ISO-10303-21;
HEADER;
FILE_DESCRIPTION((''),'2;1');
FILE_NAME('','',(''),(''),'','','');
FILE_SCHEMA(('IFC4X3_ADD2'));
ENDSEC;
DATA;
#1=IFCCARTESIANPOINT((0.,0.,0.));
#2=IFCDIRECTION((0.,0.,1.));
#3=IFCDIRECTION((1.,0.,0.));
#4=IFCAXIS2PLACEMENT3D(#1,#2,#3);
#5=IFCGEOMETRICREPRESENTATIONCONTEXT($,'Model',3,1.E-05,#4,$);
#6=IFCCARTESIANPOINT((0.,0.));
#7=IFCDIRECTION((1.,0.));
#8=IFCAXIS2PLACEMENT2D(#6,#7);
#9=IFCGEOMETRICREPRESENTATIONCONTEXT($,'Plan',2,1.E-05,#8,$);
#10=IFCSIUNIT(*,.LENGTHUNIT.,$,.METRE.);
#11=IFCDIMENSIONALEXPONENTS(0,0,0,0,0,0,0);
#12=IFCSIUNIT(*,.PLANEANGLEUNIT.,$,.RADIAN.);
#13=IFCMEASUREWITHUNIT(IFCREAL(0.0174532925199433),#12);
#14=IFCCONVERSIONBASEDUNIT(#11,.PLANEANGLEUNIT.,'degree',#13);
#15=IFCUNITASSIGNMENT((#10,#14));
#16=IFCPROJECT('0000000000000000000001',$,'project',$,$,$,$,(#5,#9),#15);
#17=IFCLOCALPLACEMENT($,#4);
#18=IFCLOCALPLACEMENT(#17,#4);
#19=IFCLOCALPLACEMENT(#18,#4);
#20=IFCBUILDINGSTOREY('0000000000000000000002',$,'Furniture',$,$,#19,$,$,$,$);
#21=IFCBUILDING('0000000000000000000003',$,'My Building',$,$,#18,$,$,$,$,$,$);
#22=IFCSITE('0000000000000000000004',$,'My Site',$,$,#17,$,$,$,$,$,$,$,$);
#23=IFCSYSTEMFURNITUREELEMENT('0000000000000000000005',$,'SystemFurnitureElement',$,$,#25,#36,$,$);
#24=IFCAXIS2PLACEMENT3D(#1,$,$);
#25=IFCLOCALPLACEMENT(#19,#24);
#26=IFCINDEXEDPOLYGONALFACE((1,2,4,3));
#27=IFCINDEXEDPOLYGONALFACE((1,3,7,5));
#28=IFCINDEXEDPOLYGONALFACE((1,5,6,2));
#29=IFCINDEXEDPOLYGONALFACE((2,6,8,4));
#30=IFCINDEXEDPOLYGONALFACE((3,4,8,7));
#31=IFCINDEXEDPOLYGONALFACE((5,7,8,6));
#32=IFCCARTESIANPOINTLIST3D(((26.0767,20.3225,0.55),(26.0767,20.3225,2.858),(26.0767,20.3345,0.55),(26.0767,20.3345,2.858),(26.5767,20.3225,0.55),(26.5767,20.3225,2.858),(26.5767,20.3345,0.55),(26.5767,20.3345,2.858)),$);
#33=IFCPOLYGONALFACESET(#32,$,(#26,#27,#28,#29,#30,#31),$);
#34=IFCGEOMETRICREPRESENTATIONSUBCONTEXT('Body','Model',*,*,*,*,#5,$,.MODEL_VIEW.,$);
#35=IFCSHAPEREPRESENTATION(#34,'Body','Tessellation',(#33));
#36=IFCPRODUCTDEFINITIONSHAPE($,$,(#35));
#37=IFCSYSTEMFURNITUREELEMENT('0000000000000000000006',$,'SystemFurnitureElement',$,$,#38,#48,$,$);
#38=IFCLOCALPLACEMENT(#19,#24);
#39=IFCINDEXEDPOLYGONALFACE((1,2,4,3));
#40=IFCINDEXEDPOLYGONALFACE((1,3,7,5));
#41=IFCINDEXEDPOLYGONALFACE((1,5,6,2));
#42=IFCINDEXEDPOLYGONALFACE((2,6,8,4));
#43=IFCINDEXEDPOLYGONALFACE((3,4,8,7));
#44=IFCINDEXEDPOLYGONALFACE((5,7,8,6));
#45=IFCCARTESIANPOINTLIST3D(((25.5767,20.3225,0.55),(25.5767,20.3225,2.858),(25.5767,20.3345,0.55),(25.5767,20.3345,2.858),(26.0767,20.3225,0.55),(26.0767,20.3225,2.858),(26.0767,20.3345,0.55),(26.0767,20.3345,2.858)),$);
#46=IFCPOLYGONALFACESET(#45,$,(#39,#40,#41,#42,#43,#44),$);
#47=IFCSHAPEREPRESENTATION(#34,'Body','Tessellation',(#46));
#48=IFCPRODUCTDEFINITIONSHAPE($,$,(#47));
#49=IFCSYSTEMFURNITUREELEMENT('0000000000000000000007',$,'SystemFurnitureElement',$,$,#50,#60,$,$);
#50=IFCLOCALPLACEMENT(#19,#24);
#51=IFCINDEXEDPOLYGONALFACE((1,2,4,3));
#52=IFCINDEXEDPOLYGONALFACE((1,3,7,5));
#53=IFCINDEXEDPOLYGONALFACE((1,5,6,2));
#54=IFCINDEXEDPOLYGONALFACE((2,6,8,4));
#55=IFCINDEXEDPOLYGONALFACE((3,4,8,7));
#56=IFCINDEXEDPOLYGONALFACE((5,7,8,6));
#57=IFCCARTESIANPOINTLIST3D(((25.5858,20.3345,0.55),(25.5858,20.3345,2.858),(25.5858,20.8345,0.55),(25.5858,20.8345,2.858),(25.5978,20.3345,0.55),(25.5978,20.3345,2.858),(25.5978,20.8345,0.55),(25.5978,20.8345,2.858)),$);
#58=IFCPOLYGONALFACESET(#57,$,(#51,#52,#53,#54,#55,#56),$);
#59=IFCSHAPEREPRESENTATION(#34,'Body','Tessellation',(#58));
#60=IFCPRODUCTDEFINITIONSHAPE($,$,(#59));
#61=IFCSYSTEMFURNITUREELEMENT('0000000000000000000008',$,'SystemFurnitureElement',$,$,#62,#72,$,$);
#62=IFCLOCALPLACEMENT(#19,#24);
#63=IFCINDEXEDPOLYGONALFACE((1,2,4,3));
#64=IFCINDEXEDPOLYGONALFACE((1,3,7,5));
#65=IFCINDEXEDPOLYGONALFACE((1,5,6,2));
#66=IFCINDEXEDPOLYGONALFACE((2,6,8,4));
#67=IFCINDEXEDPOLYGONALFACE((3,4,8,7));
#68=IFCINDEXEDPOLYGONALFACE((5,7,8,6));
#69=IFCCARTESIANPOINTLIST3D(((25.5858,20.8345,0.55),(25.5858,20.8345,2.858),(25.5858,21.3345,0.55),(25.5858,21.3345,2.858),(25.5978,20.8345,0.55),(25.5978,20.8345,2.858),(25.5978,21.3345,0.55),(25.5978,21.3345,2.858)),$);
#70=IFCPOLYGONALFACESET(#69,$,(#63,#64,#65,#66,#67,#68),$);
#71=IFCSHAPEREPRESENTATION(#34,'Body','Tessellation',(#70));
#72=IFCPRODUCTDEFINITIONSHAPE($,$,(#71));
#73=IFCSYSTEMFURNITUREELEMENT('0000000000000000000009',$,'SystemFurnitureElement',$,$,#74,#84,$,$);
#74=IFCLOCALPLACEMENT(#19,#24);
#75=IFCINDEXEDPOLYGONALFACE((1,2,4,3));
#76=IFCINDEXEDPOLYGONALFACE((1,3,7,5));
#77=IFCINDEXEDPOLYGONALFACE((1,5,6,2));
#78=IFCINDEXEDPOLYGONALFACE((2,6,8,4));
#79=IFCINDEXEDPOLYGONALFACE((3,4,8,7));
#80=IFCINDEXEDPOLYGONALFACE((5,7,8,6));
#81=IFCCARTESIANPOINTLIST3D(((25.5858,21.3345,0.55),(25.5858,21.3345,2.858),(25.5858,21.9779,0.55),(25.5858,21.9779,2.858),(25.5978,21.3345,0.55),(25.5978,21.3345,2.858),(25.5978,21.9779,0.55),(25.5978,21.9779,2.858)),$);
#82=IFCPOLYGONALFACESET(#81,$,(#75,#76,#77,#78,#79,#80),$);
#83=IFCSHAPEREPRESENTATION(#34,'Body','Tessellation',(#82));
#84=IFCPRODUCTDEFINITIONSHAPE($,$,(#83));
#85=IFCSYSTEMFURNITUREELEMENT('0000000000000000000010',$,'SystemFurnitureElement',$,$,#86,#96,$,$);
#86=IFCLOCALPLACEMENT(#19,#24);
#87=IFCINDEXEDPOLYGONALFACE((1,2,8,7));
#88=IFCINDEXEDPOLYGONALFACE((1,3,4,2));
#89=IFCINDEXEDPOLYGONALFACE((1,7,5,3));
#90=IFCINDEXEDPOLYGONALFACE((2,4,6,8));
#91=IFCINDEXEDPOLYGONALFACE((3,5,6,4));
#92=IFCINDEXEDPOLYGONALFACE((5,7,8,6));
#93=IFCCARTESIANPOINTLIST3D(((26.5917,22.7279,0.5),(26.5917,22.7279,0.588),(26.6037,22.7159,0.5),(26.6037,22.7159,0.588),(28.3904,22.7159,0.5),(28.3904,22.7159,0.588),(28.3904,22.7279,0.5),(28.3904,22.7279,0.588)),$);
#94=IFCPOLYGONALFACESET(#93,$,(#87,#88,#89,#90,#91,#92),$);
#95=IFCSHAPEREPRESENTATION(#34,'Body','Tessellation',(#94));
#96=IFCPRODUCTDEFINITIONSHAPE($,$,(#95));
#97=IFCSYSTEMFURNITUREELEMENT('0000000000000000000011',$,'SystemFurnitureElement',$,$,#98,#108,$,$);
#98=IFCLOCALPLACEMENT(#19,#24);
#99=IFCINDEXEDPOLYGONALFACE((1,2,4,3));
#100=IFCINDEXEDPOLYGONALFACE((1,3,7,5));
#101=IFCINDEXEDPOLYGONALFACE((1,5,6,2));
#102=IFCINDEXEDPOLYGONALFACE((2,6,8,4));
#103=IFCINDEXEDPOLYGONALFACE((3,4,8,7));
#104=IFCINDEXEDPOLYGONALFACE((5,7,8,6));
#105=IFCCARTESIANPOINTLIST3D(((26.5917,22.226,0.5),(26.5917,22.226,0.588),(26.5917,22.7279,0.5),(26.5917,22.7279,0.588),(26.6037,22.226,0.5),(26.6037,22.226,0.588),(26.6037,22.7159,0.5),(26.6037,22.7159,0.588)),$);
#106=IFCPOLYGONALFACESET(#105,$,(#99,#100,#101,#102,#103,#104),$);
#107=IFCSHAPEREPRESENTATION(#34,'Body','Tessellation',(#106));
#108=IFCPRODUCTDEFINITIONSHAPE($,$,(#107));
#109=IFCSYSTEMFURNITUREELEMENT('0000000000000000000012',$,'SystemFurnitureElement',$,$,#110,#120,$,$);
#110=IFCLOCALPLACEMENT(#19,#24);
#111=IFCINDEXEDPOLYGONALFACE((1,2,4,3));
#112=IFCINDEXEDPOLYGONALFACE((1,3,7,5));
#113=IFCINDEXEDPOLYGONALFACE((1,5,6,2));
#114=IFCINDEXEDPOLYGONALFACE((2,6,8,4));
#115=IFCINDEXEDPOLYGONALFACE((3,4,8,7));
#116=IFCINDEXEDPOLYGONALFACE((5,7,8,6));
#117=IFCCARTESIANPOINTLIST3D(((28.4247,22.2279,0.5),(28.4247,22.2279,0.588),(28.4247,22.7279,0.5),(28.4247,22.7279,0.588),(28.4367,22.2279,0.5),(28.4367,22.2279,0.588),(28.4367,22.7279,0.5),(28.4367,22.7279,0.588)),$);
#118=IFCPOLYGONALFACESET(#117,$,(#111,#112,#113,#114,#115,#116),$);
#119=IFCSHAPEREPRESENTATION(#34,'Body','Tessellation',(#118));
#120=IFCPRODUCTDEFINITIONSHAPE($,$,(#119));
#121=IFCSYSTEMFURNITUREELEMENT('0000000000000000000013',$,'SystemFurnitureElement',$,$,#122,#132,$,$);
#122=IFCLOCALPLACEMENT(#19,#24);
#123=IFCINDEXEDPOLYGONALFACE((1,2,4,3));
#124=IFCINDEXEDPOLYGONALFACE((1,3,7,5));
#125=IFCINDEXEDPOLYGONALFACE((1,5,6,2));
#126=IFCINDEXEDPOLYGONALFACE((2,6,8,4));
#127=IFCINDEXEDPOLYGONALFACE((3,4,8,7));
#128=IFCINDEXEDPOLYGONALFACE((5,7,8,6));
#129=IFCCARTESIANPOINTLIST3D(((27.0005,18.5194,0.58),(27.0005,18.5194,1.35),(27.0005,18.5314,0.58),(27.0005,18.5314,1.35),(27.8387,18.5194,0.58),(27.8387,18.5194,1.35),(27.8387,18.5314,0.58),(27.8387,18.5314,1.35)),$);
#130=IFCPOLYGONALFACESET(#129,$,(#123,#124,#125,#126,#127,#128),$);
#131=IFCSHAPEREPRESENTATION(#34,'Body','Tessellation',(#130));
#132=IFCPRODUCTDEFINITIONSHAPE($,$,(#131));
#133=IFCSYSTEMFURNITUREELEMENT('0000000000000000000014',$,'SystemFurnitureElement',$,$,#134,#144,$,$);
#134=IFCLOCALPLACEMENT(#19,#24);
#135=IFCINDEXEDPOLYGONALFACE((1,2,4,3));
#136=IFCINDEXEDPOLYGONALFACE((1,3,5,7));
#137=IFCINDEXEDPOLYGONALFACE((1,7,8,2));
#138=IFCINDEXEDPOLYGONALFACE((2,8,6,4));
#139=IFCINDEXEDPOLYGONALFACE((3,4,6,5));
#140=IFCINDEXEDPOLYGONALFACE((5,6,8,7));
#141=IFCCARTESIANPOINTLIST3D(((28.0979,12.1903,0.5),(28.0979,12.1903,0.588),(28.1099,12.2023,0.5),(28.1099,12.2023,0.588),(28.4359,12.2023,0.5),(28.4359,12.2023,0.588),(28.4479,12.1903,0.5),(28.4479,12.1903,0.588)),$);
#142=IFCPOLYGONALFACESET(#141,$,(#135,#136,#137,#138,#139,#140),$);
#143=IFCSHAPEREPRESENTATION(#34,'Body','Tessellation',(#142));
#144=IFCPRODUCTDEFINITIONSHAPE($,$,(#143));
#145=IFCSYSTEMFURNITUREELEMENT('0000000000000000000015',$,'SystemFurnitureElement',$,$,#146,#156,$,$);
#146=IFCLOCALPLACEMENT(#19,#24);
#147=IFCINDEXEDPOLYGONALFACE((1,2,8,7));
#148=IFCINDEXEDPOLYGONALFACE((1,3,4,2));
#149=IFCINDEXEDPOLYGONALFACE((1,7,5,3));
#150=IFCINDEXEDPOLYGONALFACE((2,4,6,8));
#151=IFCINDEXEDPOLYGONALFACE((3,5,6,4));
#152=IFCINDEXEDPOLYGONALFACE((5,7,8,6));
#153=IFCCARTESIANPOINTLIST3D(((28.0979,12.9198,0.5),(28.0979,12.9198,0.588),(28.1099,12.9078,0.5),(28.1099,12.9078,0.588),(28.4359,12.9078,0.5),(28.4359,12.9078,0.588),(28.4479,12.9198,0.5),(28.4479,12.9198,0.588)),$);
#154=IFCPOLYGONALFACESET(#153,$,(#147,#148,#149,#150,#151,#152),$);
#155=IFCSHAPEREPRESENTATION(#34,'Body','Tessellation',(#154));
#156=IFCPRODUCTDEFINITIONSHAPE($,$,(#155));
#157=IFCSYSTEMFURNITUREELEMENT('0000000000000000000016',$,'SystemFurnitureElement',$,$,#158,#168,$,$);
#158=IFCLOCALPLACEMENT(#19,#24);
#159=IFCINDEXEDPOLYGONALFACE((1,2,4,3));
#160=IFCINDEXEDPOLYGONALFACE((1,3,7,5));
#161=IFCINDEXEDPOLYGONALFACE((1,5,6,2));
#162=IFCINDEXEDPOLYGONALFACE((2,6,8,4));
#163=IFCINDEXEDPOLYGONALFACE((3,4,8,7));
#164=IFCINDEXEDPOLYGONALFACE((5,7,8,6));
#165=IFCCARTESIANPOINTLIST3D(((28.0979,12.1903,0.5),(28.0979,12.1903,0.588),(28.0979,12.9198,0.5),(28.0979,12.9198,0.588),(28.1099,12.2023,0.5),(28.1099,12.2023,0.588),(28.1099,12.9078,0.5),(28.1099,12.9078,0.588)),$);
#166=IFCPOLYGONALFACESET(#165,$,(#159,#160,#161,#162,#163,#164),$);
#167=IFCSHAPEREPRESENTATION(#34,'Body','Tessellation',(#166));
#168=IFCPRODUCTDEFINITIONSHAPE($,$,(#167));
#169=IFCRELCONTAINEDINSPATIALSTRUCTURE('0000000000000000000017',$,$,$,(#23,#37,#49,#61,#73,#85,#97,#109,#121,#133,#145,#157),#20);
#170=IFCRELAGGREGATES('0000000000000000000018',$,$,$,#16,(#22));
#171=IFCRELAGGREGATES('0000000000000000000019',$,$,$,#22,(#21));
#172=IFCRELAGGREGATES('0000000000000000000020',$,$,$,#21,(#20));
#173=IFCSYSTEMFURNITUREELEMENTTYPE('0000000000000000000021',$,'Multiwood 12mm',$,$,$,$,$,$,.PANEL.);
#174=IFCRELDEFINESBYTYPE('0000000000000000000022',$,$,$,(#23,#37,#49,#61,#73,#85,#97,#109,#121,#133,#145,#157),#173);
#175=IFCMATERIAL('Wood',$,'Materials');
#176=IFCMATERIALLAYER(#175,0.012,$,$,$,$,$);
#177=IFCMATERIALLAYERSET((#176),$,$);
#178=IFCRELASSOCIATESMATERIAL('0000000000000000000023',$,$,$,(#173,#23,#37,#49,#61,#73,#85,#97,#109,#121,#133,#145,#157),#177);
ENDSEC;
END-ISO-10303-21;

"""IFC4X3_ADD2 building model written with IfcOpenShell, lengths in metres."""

from ifc_helpers import new_model, entity, si_unit, converted_unit, frame, origin_with_axes, origin_2d_with_axis, place, context, subcontext, project, spatial, line, indexed_curve, outline, extrude, material, layer, layer_set, layer_usage, type_object, element, save


model = new_model("IFC4X3_ADD2")

# Units and contexts
model_context = context("Model", 3, precision=1e-05, world=origin_with_axes())
plan_context = context("Plan", 2, precision=1e-05, world=origin_2d_with_axis())
body_context = subcontext(model_context, "Body", "Model", "MODEL_VIEW")
ifc_project = project(units=[si_unit("LENGTHUNIT", "METRE"), converted_unit("PLANEANGLEUNIT", "degree", entity("IfcReal", 0.0174532925199433), si_unit("PLANEANGLEUNIT", "RADIAN"), dimensions=[0, 0, 0, 0, 0, 0, 0])], contexts=[model_context, plan_context])

# Site, building, storey
site_placement = place(None, origin_with_axes())
site = spatial("IfcSite", under=ifc_project, at=site_placement, Name="My Site")
building_placement = place(site_placement, origin_with_axes())
building = spatial("IfcBuilding", under=site, at=building_placement, Name="My Building")
storey_placement = place(building_placement, origin_with_axes())
storey = spatial("IfcBuildingStorey", under=building, at=storey_placement, Name="Furniture")

# System furniture elements
ifc_material = material(Name="Wood", Category="Materials")
ifc_layer_1 = layer(ifc_material, 0.012)
ifc_layer_set_1 = layer_set([ifc_layer_1])
ifc_layer_usage_1 = layer_usage(ifc_layer_set_1, "AXIS2", "POSITIVE", 0.0)
system_furniture_element_type_1 = type_object("IfcSystemFurnitureElementType", Name="Multiwood 12mm", PredefinedType="PANEL", material=ifc_layer_set_1)
system_furniture_element_1_placement = place(storey_placement, frame((26.5767, 20.3345, 0.55), z_axis=(0.0, 0.0, 1.0), x_axis=(-1.0, 0.000001, 0.0)))
element("IfcSystemFurnitureElement", 1, at=system_furniture_element_1_placement, inside=storey, type_object=system_furniture_element_type_1, material=ifc_layer_usage_1, Name="SystemFurnitureElement", context=body_context, shape_type="SweptSolid", body=[
    extrude(outline(indexed_curve([(0.0, 0.0), (0.0, 0.012), (0.5, 0.012), (0.5, 0.0)], segments=[line(1, 2, 3, 4, 1)])), origin_with_axes(), (0.0, 0.0, 1.0), 2.308),
])
ifc_layer_usage_2 = layer_usage(ifc_layer_set_1, "AXIS2", "POSITIVE", 0.0)
system_furniture_element_2_placement = place(storey_placement, frame((26.0767, 20.3345, 0.55), z_axis=(0.0, 0.0, 1.0), x_axis=(-1.0, 0.000001, 0.0)))
element("IfcSystemFurnitureElement", 2, at=system_furniture_element_2_placement, inside=storey, type_object=system_furniture_element_type_1, material=ifc_layer_usage_2, Name="SystemFurnitureElement", context=body_context, shape_type="SweptSolid", body=[
    extrude(outline(indexed_curve([(0.0, 0.0), (0.0, 0.012), (0.5, 0.012), (0.5, 0.0)], segments=[line(1, 2, 3, 4, 1)])), origin_with_axes(), (0.0, 0.0, 1.0), 2.308),
])
ifc_layer_usage_3 = layer_usage(ifc_layer_set_1, "AXIS2", "POSITIVE", 0.0)
system_furniture_element_3_placement = place(storey_placement, frame((25.5978, 20.3345, 0.55), z_axis=(0.0, 0.0, 1.0), x_axis=(0.0, 1.0, 0.0)))
element("IfcSystemFurnitureElement", 3, at=system_furniture_element_3_placement, inside=storey, type_object=system_furniture_element_type_1, material=ifc_layer_usage_3, Name="SystemFurnitureElement", context=body_context, shape_type="SweptSolid", body=[
    extrude(outline(indexed_curve([(0.0, 0.0), (0.0, 0.012), (0.5, 0.012), (0.5, 0.0)], segments=[line(1, 2, 3, 4, 1)])), origin_with_axes(), (0.0, 0.0, 1.0), 2.308),
])
ifc_layer_usage_4 = layer_usage(ifc_layer_set_1, "AXIS2", "POSITIVE", 0.0)
system_furniture_element_4_placement = place(storey_placement, frame((25.5978, 20.8345, 0.55), z_axis=(0.0, 0.0, 1.0), x_axis=(0.0, 1.0, 0.0)))
element("IfcSystemFurnitureElement", 4, at=system_furniture_element_4_placement, inside=storey, type_object=system_furniture_element_type_1, material=ifc_layer_usage_4, Name="SystemFurnitureElement", context=body_context, shape_type="SweptSolid", body=[
    extrude(outline(indexed_curve([(0.0, 0.0), (0.0, 0.012), (0.5, 0.012), (0.5, 0.0)], segments=[line(1, 2, 3, 4, 1)])), origin_with_axes(), (0.0, 0.0, 1.0), 2.308),
])
ifc_layer_usage_5 = layer_usage(ifc_layer_set_1, "AXIS2", "POSITIVE", 0.0)
system_furniture_element_5_placement = place(storey_placement, frame((25.5978, 21.3345, 0.55), z_axis=(0.0, 0.0, 1.0), x_axis=(0.0, 1.0, 0.0)))
element("IfcSystemFurnitureElement", 5, at=system_furniture_element_5_placement, inside=storey, type_object=system_furniture_element_type_1, material=ifc_layer_usage_5, Name="SystemFurnitureElement", context=body_context, shape_type="SweptSolid", body=[
    extrude(outline(indexed_curve([(0.0, 0.0), (0.0, 0.012), (0.6434, 0.012), (0.6434, 0.0)], segments=[line(1, 2, 3, 4, 1)])), origin_with_axes(), (0.0, 0.0, 1.0), 2.308),
])
ifc_layer_usage_6 = layer_usage(ifc_layer_set_1, "AXIS2", "POSITIVE", 0.0)
system_furniture_element_6_placement = place(storey_placement, frame((28.3904, 22.7279, 0.5), z_axis=(0.0, 0.0, 1.0), x_axis=(-1.0, 0.000001, 0.0)))
element("IfcSystemFurnitureElement", 6, at=system_furniture_element_6_placement, inside=storey, type_object=system_furniture_element_type_1, material=ifc_layer_usage_6, Name="SystemFurnitureElement", context=body_context, shape_type="SweptSolid", body=[
    extrude(outline(indexed_curve([(0.0, 0.0), (0.0, 0.012), (1.7868, 0.012), (1.7988, 0.0)], segments=[line(1, 2, 3, 4, 1)])), origin_with_axes(), (0.0, 0.0, 1.0), 0.088),
])
ifc_layer_usage_7 = layer_usage(ifc_layer_set_1, "AXIS2", "POSITIVE", 0.0)
system_furniture_element_7_placement = place(storey_placement, frame((26.5917, 22.7279, 0.5), z_axis=(0.0, 0.0, 1.0), x_axis=(-0.000001, -1.0, 0.0)))
element("IfcSystemFurnitureElement", 7, at=system_furniture_element_7_placement, inside=storey, type_object=system_furniture_element_type_1, material=ifc_layer_usage_7, Name="SystemFurnitureElement", context=body_context, shape_type="SweptSolid", body=[
    extrude(outline(indexed_curve([(0.0, 0.0), (0.012, 0.012), (0.5019, 0.012), (0.5019, 0.0)], segments=[line(1, 2, 3, 4, 1)])), origin_with_axes(), (0.0, 0.0, 1.0), 0.088),
])
ifc_layer_usage_8 = layer_usage(ifc_layer_set_1, "AXIS2", "POSITIVE", 0.0)
system_furniture_element_8_placement = place(storey_placement, frame((28.4367, 22.2279, 0.5), z_axis=(0.0, 0.0, 1.0), x_axis=(0.000001, 1.0, 0.0)))
element("IfcSystemFurnitureElement", 8, at=system_furniture_element_8_placement, inside=storey, type_object=system_furniture_element_type_1, material=ifc_layer_usage_8, Name="SystemFurnitureElement", context=body_context, shape_type="SweptSolid", body=[
    extrude(outline(indexed_curve([(0.0, 0.0), (0.0, 0.012), (0.5, 0.012), (0.5, 0.0)], segments=[line(1, 2, 3, 4, 1)])), origin_with_axes(), (0.0, 0.0, 1.0), 0.088),
])
ifc_layer_usage_9 = layer_usage(ifc_layer_set_1, "AXIS2", "POSITIVE", 0.0)
system_furniture_element_9_placement = place(storey_placement, frame((27.8387, 18.5314, 0.58), z_axis=(0.0, 0.0, 1.0), x_axis=(-1.0, 0.0, 0.0)))
element("IfcSystemFurnitureElement", 9, at=system_furniture_element_9_placement, inside=storey, type_object=system_furniture_element_type_1, material=ifc_layer_usage_9, Name="SystemFurnitureElement", context=body_context, shape_type="SweptSolid", body=[
    extrude(outline(indexed_curve([(0.0, 0.0), (0.0, 0.012), (0.8382, 0.012), (0.8382, 0.0)], segments=[line(1, 2, 3, 4, 1)])), origin_with_axes(), (0.0, 0.0, 1.0), 0.77),
])
ifc_layer_usage_10 = layer_usage(ifc_layer_set_1, "AXIS2", "POSITIVE", 0.0)
system_furniture_element_10_placement = place(storey_placement, frame((28.0979, 12.1903, 0.5), z_axis=(0.0, 0.0, 1.0), x_axis=(1.0, 0.0, 0.0)))
element("IfcSystemFurnitureElement", 10, at=system_furniture_element_10_placement, inside=storey, type_object=system_furniture_element_type_1, material=ifc_layer_usage_10, Name="SystemFurnitureElement", context=body_context, shape_type="SweptSolid", body=[
    extrude(outline(indexed_curve([(0.0, 0.0), (0.012, 0.012), (0.338, 0.012), (0.35, 0.0)], segments=[line(1, 2, 3, 4, 1)])), origin_with_axes(), (0.0, 0.0, 1.0), 0.088),
])
ifc_layer_usage_11 = layer_usage(ifc_layer_set_1, "AXIS2", "POSITIVE", 0.0)
system_furniture_element_11_placement = place(storey_placement, frame((28.0979, 12.9078, 0.5), z_axis=(0.0, 0.0, 1.0), x_axis=(1.0, 0.0, 0.0)))
element("IfcSystemFurnitureElement", 11, at=system_furniture_element_11_placement, inside=storey, type_object=system_furniture_element_type_1, material=ifc_layer_usage_11, Name="SystemFurnitureElement", context=body_context, shape_type="SweptSolid", body=[
    extrude(outline(indexed_curve([(0.012, 0.0), (0.0, 0.012), (0.35, 0.012), (0.338, 0.0)], segments=[line(1, 2, 3, 4, 1)])), origin_with_axes(), (0.0, 0.0, 1.0), 0.088),
])
ifc_layer_usage_12 = layer_usage(ifc_layer_set_1, "AXIS2", "POSITIVE", 0.0)
system_furniture_element_12_placement = place(storey_placement, frame((28.0979, 12.9078, 0.5), z_axis=(0.0, 0.0, 1.0), x_axis=(0.0, -1.0, 0.0)))
element("IfcSystemFurnitureElement", 12, at=system_furniture_element_12_placement, inside=storey, type_object=system_furniture_element_type_1, material=ifc_layer_usage_12, Name="SystemFurnitureElement", context=body_context, shape_type="SweptSolid", body=[
    extrude(outline(indexed_curve([(-0.012, 0.0), (0.0, 0.012), (0.7055, 0.012), (0.7175, 0.0)], segments=[line(1, 2, 3, 4, 1)])), origin_with_axes(), (0.0, 0.0, 1.0), 0.088),
])

save(model, "model.ifc")
